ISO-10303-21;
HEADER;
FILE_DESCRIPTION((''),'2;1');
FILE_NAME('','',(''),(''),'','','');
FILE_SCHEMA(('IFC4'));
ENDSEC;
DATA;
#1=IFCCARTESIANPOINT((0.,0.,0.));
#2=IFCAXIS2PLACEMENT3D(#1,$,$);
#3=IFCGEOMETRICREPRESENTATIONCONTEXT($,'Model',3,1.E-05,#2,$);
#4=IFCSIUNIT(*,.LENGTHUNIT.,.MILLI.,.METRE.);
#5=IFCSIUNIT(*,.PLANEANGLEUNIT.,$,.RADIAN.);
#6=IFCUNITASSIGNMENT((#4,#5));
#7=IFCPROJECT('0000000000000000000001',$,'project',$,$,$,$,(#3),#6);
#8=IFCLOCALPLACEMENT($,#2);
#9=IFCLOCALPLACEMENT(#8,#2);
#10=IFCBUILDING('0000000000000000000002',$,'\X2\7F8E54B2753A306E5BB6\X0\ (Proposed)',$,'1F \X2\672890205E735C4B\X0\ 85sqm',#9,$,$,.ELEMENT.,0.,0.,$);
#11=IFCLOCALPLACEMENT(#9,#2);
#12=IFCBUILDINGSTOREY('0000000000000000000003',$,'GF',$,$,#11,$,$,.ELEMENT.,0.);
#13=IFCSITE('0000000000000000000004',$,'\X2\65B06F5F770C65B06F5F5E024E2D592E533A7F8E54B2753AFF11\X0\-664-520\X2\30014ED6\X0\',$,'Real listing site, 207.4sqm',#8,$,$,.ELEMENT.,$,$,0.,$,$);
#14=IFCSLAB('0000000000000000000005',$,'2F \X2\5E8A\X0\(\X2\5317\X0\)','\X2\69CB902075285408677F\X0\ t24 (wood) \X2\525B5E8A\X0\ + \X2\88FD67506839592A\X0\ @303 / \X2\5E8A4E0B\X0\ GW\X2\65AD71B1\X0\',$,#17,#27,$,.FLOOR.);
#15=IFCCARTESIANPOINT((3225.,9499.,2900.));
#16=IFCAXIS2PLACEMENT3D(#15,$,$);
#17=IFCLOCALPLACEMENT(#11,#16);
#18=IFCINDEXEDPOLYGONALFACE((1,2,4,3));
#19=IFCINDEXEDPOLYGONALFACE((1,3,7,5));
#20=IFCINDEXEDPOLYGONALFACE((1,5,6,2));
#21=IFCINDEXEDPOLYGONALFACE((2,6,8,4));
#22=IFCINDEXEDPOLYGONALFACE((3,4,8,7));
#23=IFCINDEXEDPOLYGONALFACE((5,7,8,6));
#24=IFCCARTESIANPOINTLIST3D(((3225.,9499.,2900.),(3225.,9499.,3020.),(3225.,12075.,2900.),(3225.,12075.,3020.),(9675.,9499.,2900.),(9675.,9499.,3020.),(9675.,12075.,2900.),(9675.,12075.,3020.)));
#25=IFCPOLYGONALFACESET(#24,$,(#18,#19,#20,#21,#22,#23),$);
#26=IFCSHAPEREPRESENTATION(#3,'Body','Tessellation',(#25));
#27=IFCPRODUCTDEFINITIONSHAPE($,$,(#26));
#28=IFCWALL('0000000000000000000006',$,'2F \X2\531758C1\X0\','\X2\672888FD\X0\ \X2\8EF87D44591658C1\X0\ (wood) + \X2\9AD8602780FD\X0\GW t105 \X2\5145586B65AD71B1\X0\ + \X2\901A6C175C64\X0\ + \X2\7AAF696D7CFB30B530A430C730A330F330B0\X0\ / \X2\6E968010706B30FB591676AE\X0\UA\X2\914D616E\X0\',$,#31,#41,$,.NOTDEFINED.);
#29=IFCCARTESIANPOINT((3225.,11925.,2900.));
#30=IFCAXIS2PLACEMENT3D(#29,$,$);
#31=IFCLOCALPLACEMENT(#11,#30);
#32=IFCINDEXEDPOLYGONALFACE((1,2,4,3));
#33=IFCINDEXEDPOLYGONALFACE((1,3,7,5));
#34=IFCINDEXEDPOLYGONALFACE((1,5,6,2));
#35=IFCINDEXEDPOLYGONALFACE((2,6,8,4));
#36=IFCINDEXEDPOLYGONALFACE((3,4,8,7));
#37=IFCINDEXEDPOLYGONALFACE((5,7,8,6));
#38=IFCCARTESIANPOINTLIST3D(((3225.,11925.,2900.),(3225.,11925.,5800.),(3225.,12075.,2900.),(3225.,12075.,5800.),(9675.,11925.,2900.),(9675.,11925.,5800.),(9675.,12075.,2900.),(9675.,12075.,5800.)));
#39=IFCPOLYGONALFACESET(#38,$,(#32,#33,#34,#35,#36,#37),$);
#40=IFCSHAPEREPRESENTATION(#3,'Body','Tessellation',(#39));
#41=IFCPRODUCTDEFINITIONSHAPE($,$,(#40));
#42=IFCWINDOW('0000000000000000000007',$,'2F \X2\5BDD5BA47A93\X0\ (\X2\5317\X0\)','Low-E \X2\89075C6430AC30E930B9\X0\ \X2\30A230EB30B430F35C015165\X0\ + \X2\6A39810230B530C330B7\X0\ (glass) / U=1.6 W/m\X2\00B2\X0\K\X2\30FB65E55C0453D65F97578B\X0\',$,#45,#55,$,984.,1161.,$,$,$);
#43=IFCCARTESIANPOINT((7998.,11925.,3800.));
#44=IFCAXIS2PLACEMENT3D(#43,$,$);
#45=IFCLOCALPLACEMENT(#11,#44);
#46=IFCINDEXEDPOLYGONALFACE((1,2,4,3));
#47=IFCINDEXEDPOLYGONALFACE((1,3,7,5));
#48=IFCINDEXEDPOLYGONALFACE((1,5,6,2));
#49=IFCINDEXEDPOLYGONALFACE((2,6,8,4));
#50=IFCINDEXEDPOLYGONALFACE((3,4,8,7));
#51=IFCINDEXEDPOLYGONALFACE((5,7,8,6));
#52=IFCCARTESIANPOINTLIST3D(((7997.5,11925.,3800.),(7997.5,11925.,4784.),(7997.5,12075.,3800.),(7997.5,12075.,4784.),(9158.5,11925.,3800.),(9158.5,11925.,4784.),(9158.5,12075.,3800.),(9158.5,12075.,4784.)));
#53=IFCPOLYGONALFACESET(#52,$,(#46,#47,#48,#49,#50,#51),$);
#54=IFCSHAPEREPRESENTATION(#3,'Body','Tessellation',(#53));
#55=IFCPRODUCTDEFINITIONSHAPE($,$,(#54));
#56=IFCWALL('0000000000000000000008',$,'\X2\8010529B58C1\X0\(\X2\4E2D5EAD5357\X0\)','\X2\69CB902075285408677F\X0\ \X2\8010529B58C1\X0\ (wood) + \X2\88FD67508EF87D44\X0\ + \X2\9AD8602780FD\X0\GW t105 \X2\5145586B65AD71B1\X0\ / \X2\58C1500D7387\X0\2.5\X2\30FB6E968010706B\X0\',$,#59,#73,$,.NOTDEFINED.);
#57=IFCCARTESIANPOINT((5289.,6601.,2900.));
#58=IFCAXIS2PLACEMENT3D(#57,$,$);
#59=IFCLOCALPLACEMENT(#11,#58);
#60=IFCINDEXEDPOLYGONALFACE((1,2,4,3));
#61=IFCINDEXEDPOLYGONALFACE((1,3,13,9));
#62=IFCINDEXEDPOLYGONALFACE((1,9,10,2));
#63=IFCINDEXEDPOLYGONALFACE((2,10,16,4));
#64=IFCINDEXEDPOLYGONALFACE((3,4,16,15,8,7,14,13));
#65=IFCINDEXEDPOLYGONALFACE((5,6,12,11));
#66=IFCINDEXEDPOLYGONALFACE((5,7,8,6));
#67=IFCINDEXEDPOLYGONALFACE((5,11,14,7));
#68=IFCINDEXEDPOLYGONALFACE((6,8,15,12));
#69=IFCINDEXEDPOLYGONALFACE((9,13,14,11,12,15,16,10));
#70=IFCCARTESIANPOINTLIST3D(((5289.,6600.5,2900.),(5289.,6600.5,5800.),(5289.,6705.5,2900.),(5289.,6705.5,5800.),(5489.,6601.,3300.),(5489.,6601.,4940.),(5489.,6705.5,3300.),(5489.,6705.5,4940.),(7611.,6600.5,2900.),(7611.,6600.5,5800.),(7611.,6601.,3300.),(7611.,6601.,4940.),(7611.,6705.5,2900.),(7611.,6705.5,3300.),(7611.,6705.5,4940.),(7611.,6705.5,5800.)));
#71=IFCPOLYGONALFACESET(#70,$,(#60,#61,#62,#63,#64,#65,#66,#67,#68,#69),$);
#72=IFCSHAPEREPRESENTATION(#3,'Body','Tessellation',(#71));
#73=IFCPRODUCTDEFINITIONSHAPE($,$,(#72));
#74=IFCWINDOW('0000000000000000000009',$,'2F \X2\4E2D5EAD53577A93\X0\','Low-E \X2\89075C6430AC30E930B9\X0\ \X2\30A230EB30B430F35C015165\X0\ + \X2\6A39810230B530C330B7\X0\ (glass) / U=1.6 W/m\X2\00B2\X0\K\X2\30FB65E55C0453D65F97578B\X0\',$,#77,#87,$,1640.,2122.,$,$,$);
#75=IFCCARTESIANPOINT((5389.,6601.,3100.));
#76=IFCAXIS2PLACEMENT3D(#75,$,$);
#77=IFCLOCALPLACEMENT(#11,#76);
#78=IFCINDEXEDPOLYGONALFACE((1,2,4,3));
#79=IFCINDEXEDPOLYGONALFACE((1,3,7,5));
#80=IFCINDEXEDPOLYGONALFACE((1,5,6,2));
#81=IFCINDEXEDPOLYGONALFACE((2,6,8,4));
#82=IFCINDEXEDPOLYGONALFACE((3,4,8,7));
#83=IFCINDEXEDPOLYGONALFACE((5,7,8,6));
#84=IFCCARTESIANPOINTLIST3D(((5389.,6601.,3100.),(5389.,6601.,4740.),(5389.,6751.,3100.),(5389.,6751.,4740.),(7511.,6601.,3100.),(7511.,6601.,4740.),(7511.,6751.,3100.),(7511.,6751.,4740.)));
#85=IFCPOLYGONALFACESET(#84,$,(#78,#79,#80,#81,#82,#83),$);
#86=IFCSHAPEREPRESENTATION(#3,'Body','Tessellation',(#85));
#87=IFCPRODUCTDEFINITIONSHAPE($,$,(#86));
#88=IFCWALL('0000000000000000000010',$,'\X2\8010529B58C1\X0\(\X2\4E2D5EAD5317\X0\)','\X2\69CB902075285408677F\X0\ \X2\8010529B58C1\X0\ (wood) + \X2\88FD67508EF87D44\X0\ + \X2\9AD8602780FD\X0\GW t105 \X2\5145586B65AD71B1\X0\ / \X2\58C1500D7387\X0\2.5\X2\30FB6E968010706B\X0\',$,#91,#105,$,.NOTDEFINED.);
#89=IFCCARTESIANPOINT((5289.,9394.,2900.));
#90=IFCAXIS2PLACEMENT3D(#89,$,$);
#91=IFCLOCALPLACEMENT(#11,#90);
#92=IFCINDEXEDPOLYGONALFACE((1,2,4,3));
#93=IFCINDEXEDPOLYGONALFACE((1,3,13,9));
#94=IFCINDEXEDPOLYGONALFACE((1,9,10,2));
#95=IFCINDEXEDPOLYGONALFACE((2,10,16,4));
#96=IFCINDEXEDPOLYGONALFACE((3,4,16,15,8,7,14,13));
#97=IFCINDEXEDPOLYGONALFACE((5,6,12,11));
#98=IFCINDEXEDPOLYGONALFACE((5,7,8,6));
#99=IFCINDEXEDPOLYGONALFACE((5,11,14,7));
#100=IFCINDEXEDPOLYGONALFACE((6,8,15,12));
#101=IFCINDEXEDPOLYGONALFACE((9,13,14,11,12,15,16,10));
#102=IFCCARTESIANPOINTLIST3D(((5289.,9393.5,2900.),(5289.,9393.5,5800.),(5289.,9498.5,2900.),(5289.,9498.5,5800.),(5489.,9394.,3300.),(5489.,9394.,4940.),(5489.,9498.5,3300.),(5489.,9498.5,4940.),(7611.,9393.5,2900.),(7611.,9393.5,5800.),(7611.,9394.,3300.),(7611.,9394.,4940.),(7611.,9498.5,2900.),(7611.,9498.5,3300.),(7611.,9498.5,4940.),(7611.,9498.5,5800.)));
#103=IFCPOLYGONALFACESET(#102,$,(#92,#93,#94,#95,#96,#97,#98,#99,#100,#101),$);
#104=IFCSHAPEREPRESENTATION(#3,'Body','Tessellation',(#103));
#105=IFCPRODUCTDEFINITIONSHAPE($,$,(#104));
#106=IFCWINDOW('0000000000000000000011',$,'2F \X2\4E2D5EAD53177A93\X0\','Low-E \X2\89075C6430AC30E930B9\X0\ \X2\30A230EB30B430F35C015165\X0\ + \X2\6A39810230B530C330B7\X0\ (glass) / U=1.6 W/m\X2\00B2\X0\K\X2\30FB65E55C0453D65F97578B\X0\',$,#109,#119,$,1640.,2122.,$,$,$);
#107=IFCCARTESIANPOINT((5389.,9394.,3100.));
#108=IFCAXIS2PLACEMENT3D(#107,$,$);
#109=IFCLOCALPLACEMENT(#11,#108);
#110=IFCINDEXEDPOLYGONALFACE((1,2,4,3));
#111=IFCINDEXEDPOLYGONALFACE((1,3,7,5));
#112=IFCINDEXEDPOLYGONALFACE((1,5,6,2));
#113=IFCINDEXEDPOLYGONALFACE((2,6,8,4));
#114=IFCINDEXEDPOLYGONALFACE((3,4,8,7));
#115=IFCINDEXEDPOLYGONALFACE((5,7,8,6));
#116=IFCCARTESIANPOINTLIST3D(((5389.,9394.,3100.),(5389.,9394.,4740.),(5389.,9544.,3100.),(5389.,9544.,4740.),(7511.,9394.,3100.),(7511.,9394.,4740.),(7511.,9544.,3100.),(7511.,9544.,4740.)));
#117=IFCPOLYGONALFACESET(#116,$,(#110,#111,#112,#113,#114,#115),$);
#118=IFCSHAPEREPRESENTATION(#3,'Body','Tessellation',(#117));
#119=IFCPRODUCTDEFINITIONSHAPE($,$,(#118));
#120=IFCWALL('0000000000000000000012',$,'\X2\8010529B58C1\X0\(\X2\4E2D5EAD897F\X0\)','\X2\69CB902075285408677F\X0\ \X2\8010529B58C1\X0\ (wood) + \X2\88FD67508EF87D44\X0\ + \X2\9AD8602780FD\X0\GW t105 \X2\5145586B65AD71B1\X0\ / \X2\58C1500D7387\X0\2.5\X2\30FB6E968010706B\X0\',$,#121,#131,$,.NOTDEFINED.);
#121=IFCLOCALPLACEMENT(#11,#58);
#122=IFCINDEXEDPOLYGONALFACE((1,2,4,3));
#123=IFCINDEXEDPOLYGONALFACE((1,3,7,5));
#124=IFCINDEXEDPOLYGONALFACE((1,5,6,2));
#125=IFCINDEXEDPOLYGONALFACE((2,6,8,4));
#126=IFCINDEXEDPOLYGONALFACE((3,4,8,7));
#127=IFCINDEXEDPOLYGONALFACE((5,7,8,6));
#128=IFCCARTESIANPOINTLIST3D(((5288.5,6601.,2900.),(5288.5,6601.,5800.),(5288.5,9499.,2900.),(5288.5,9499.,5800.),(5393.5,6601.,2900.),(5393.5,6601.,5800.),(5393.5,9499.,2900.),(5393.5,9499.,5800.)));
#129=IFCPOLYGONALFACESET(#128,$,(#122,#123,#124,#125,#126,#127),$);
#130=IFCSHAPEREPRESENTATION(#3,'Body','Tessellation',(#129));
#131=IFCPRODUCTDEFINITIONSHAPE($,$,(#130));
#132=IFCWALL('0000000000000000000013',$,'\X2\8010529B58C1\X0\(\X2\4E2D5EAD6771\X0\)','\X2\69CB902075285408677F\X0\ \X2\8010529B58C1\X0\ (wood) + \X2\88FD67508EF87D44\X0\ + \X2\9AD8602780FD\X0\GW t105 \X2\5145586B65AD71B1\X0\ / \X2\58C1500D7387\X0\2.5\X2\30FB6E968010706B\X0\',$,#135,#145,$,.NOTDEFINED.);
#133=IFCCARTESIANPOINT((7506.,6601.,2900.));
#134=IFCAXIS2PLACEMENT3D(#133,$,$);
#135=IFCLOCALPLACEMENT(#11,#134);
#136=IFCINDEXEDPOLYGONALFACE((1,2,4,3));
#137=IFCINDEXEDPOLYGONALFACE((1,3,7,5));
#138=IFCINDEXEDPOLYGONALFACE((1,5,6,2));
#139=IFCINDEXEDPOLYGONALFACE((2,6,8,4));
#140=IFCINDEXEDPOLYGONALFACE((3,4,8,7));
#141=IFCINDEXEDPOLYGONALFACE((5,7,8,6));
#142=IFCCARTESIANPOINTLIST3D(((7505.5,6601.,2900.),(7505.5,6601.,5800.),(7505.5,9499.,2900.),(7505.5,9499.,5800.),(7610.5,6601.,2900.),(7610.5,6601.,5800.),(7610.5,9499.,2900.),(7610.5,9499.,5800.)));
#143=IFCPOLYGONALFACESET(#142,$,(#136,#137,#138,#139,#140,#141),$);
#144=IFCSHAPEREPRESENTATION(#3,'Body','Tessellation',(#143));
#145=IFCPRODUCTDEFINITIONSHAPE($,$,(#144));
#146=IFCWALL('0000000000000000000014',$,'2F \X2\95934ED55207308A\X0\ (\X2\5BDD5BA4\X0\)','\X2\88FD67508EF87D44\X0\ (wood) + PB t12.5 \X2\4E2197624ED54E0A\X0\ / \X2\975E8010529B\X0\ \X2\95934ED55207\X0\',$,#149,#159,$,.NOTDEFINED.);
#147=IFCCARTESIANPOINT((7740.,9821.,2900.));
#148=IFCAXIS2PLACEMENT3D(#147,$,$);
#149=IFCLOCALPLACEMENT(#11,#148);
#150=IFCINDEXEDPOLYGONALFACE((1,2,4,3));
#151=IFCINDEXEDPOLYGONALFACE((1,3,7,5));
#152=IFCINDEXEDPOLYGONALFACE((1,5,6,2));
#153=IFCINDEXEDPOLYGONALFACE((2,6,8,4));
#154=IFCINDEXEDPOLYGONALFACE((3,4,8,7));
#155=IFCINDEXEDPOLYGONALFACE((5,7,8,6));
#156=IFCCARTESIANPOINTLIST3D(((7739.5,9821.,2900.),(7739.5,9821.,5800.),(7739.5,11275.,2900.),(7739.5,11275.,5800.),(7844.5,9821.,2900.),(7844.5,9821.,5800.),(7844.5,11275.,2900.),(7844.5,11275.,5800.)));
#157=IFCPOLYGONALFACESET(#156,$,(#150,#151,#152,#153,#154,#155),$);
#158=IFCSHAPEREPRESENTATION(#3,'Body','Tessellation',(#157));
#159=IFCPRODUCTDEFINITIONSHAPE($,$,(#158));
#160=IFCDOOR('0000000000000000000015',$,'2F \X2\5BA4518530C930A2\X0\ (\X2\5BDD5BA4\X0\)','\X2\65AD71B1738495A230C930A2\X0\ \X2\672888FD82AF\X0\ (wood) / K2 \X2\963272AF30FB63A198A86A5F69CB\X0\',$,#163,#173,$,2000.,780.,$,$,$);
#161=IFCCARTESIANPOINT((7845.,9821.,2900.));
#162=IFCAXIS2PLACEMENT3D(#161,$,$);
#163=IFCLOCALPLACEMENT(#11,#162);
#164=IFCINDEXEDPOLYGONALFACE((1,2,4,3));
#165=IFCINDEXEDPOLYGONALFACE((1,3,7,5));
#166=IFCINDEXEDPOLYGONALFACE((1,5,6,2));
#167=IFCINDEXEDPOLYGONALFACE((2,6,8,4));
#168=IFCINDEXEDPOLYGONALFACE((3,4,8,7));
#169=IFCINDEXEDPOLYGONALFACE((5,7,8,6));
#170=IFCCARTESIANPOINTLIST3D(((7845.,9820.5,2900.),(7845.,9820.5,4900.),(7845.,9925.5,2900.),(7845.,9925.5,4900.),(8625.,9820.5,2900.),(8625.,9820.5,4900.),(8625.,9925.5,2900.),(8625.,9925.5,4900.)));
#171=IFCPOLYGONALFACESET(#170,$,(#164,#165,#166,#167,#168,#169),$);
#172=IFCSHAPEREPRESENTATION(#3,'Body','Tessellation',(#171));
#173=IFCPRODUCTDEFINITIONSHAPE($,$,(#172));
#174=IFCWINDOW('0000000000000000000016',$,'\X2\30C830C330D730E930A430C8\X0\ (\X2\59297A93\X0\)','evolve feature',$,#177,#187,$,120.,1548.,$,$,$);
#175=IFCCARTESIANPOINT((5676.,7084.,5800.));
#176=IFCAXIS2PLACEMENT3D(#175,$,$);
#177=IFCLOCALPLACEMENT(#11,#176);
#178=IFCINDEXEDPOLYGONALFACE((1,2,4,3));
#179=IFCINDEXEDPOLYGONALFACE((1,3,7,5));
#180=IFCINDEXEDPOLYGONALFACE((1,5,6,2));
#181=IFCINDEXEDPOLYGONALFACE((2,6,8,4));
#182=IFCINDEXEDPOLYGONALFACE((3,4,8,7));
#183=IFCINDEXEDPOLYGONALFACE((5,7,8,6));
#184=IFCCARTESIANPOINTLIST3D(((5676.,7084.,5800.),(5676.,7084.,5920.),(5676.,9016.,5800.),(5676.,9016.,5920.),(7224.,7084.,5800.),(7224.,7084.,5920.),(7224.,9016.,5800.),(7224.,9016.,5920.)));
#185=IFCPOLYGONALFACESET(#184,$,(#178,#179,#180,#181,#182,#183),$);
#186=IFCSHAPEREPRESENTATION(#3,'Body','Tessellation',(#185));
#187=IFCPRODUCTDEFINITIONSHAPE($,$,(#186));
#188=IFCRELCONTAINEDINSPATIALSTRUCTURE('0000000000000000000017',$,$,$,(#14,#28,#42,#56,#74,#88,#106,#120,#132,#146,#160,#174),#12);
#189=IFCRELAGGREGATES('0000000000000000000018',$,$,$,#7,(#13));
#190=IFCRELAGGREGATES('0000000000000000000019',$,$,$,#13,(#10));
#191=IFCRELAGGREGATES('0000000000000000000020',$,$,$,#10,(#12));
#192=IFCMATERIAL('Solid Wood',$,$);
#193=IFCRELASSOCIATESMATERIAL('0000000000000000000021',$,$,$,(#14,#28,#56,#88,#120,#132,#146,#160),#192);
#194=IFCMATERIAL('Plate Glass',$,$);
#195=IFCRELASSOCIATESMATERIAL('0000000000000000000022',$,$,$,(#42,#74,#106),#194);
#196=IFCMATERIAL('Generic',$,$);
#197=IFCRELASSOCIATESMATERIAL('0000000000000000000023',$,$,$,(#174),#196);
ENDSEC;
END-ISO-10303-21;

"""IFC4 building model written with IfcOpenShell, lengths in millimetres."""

from ifc_helpers import new_model, si_unit, frame, frame_2d, origin, place, context, project, spatial, rectangle, extrude, material, element, fill, save


model = new_model("IFC4")

# Units and contexts
model_context = context("Model", 3, precision=1e-05, world=origin())
ifc_project = project(units=[si_unit("LENGTHUNIT", "METRE", prefix="MILLI"), si_unit("PLANEANGLEUNIT", "RADIAN")], contexts=[model_context])

# Site, building, storey
site_placement = place(None, origin())
site = spatial("IfcSite", under=ifc_project, at=site_placement, Name="新潟県新潟市中央区美咲町１-664-520、他", ObjectType="Real listing site, 207.4sqm", CompositionType="ELEMENT", RefElevation=0.0)
building_placement = place(site_placement, origin())
building = spatial("IfcBuilding", under=site, at=building_placement, Name="美咲町の家 (Proposed)", ObjectType="1F 木造平屋 85sqm", CompositionType="ELEMENT", ElevationOfRefHeight=0.0, ElevationOfTerrain=0.0)
storey_placement = place(building_placement, origin())
storey = spatial("IfcBuildingStorey", under=building, at=storey_placement, Name="GF", CompositionType="ELEMENT", Elevation=0.0)

# Slab
ifc_material_1 = material(Name="Solid Wood")
slab_placement = place(storey_placement, frame((3225.0, 9499.0, 2900.0)))
element("IfcSlab", 1, at=slab_placement, inside=storey, material=ifc_material_1, Name="2F 床(北)", Description="構造用合板 t24 (wood) 剛床 + 製材根太 @303 / 床下 GW断熱", PredefinedType="FLOOR", context=model_context, shape_type="SweptSolid", body=[
    extrude(rectangle(XDim=6450.0, YDim=2576.0, at=frame_2d((3225.0, 1288.0))), frame((3225.0, 9499.0, 2900.0)), (0.0, 0.0, 1.0), 120.0),
])

# Walls, openings, windows
wall_1_placement = place(storey_placement, frame((3225.0, 11925.0, 2900.0)))
wall_1 = element("IfcWall", 2, at=wall_1_placement, inside=storey, material=ifc_material_1, Name="2F 北壁", Description="木製 軸組外壁 (wood) + 高性能GW t105 充填断熱 + 通気層 + 窯業系サイディング / 準耐火・外皮UA配慮", PredefinedType="NOTDEFINED", context=model_context, shape_type="SweptSolid", body=[
    extrude(rectangle(XDim=6450.0, YDim=150.0, at=frame_2d((3225.0, 75.0))), frame((3225.0, 11925.0, 2900.0)), (0.0, 0.0, 1.0), 2900.0),
])
opening_1_placement = place(storey_placement, frame((7998.0, 11925.0, 3800.0)))
opening_1 = element("IfcOpeningElement", 3, at=opening_1_placement, cuts=wall_1, PredefinedType="NOTDEFINED", context=model_context, shape_type="SweptSolid", body=[
    extrude(rectangle(XDim=1161.0, YDim=150.0, at=frame_2d((580.0, 75.0))), frame((7998.0, 11925.0, 3800.0)), (0.0, 0.0, 1.0), 984.0),
])
ifc_material_2 = material(Name="Plate Glass")
window_1_placement = place(storey_placement, frame((7998.0, 11925.0, 3800.0)))
window_1 = element("IfcWindow", 4, at=window_1_placement, inside=storey, material=ifc_material_2, Name="2F 寝室窓 (北)", Description="Low-E 複層ガラス アルゴン封入 + 樹脂サッシ (glass) / U=1.6 W/m²K・日射取得型", OverallHeight=984.0, OverallWidth=1161.0, context=model_context, shape_type="SweptSolid", body=[
    extrude(rectangle(XDim=1161.0, YDim=150.0, at=frame_2d((580.0, 75.0))), frame((7998.0, 11925.0, 3800.0)), (0.0, 0.0, 1.0), 984.0),
])
fill(opening_1, window_1)
wall_2_placement = place(storey_placement, frame((5289.0, 6601.0, 2900.0)))
wall_2 = element("IfcWall", 5, at=wall_2_placement, inside=storey, material=ifc_material_1, Name="耐力壁(中庭南)", Description="構造用合板 耐力壁 (wood) + 製材軸組 + 高性能GW t105 充填断熱 / 壁倍率2.5・準耐火", PredefinedType="NOTDEFINED", context=model_context, shape_type="SweptSolid", body=[
    extrude(rectangle(XDim=2322.0, YDim=105.0, at=frame_2d((1161.0, 52.0))), frame((5289.0, 6601.0, 2900.0)), (0.0, 0.0, 1.0), 2900.0),
])
opening_2_placement = place(storey_placement, frame((5389.0, 6601.0, 3100.0)))
opening_2 = element("IfcOpeningElement", 6, at=opening_2_placement, cuts=wall_2, PredefinedType="NOTDEFINED", context=model_context, shape_type="SweptSolid", body=[
    extrude(rectangle(XDim=2122.0, YDim=150.0, at=frame_2d((1061.0, 75.0))), frame((5389.0, 6601.0, 3100.0)), (0.0, 0.0, 1.0), 1640.0),
])
window_2_placement = place(storey_placement, frame((5389.0, 6601.0, 3100.0)))
window_2 = element("IfcWindow", 7, at=window_2_placement, inside=storey, material=ifc_material_2, Name="2F 中庭南窓", Description="Low-E 複層ガラス アルゴン封入 + 樹脂サッシ (glass) / U=1.6 W/m²K・日射取得型", OverallHeight=1640.0, OverallWidth=2122.0, context=model_context, shape_type="SweptSolid", body=[
    extrude(rectangle(XDim=2122.0, YDim=150.0, at=frame_2d((1061.0, 75.0))), frame((5389.0, 6601.0, 3100.0)), (0.0, 0.0, 1.0), 1640.0),
])
fill(opening_2, window_2)
wall_3_placement = place(storey_placement, frame((5289.0, 9394.0, 2900.0)))
wall_3 = element("IfcWall", 8, at=wall_3_placement, inside=storey, material=ifc_material_1, Name="耐力壁(中庭北)", Description="構造用合板 耐力壁 (wood) + 製材軸組 + 高性能GW t105 充填断熱 / 壁倍率2.5・準耐火", PredefinedType="NOTDEFINED", context=model_context, shape_type="SweptSolid", body=[
    extrude(rectangle(XDim=2322.0, YDim=105.0, at=frame_2d((1161.0, 52.0))), frame((5289.0, 9394.0, 2900.0)), (0.0, 0.0, 1.0), 2900.0),
])
opening_3_placement = place(storey_placement, frame((5389.0, 9394.0, 3100.0)))
opening_3 = element("IfcOpeningElement", 9, at=opening_3_placement, cuts=wall_3, PredefinedType="NOTDEFINED", context=model_context, shape_type="SweptSolid", body=[
    extrude(rectangle(XDim=2122.0, YDim=150.0, at=frame_2d((1061.0, 75.0))), frame((5389.0, 9394.0, 3100.0)), (0.0, 0.0, 1.0), 1640.0),
])
window_3_placement = place(storey_placement, frame((5389.0, 9394.0, 3100.0)))
window_3 = element("IfcWindow", 10, at=window_3_placement, inside=storey, material=ifc_material_2, Name="2F 中庭北窓", Description="Low-E 複層ガラス アルゴン封入 + 樹脂サッシ (glass) / U=1.6 W/m²K・日射取得型", OverallHeight=1640.0, OverallWidth=2122.0, context=model_context, shape_type="SweptSolid", body=[
    extrude(rectangle(XDim=2122.0, YDim=150.0, at=frame_2d((1061.0, 75.0))), frame((5389.0, 9394.0, 3100.0)), (0.0, 0.0, 1.0), 1640.0),
])
fill(opening_3, window_3)

# Walls
wall_4_placement = place(storey_placement, frame((5289.0, 6601.0, 2900.0)))
element("IfcWall", 11, at=wall_4_placement, inside=storey, material=ifc_material_1, Name="耐力壁(中庭西)", Description="構造用合板 耐力壁 (wood) + 製材軸組 + 高性能GW t105 充填断熱 / 壁倍率2.5・準耐火", PredefinedType="NOTDEFINED", context=model_context, shape_type="SweptSolid", body=[
    extrude(rectangle(XDim=105.0, YDim=2898.0, at=frame_2d((52.0, 1449.0))), frame((5289.0, 6601.0, 2900.0)), (0.0, 0.0, 1.0), 2900.0),
])
wall_5_placement = place(storey_placement, frame((7506.0, 6601.0, 2900.0)))
element("IfcWall", 12, at=wall_5_placement, inside=storey, material=ifc_material_1, Name="耐力壁(中庭東)", Description="構造用合板 耐力壁 (wood) + 製材軸組 + 高性能GW t105 充填断熱 / 壁倍率2.5・準耐火", PredefinedType="NOTDEFINED", context=model_context, shape_type="SweptSolid", body=[
    extrude(rectangle(XDim=105.0, YDim=2898.0, at=frame_2d((52.0, 1449.0))), frame((7506.0, 6601.0, 2900.0)), (0.0, 0.0, 1.0), 2900.0),
])
wall_6_placement = place(storey_placement, frame((7740.0, 9821.0, 2900.0)))
element("IfcWall", 13, at=wall_6_placement, inside=storey, material=ifc_material_1, Name="2F 間仕切り (寝室)", Description="製材軸組 (wood) + PB t12.5 両面仕上 / 非耐力 間仕切", PredefinedType="NOTDEFINED", context=model_context, shape_type="SweptSolid", body=[
    extrude(rectangle(XDim=105.0, YDim=1454.0, at=frame_2d((52.0, 727.0))), frame((7740.0, 9821.0, 2900.0)), (0.0, 0.0, 1.0), 2900.0),
])

# Door
door_placement = place(storey_placement, frame((7845.0, 9821.0, 2900.0)))
element("IfcDoor", 14, at=door_placement, inside=storey, material=ifc_material_1, Name="2F 室内ドア (寝室)", Description="断熱玄関ドア 木製芯 (wood) / K2 防犯・採風機構", OverallHeight=2000.0, OverallWidth=780.0, context=model_context, shape_type="SweptSolid", body=[
    extrude(rectangle(XDim=780.0, YDim=105.0, at=frame_2d((390.0, 52.0))), frame((7845.0, 9821.0, 2900.0)), (0.0, 0.0, 1.0), 2000.0),
])

# Window
ifc_material_3 = material(Name="Generic")
window_4_placement = place(storey_placement, frame((5676.0, 7084.0, 5800.0)))
element("IfcWindow", 15, at=window_4_placement, inside=storey, material=ifc_material_3, Name="トップライト (天窓)", Description="evolve feature", OverallHeight=120.0, OverallWidth=1548.0, context=model_context, shape_type="SweptSolid", body=[
    extrude(rectangle(XDim=1548.0, YDim=1932.0, at=frame_2d((774.0, 966.0))), frame((5676.0, 7084.0, 5800.0)), (0.0, 0.0, 1.0), 120.0),
])

save(model, "model.ifc")
